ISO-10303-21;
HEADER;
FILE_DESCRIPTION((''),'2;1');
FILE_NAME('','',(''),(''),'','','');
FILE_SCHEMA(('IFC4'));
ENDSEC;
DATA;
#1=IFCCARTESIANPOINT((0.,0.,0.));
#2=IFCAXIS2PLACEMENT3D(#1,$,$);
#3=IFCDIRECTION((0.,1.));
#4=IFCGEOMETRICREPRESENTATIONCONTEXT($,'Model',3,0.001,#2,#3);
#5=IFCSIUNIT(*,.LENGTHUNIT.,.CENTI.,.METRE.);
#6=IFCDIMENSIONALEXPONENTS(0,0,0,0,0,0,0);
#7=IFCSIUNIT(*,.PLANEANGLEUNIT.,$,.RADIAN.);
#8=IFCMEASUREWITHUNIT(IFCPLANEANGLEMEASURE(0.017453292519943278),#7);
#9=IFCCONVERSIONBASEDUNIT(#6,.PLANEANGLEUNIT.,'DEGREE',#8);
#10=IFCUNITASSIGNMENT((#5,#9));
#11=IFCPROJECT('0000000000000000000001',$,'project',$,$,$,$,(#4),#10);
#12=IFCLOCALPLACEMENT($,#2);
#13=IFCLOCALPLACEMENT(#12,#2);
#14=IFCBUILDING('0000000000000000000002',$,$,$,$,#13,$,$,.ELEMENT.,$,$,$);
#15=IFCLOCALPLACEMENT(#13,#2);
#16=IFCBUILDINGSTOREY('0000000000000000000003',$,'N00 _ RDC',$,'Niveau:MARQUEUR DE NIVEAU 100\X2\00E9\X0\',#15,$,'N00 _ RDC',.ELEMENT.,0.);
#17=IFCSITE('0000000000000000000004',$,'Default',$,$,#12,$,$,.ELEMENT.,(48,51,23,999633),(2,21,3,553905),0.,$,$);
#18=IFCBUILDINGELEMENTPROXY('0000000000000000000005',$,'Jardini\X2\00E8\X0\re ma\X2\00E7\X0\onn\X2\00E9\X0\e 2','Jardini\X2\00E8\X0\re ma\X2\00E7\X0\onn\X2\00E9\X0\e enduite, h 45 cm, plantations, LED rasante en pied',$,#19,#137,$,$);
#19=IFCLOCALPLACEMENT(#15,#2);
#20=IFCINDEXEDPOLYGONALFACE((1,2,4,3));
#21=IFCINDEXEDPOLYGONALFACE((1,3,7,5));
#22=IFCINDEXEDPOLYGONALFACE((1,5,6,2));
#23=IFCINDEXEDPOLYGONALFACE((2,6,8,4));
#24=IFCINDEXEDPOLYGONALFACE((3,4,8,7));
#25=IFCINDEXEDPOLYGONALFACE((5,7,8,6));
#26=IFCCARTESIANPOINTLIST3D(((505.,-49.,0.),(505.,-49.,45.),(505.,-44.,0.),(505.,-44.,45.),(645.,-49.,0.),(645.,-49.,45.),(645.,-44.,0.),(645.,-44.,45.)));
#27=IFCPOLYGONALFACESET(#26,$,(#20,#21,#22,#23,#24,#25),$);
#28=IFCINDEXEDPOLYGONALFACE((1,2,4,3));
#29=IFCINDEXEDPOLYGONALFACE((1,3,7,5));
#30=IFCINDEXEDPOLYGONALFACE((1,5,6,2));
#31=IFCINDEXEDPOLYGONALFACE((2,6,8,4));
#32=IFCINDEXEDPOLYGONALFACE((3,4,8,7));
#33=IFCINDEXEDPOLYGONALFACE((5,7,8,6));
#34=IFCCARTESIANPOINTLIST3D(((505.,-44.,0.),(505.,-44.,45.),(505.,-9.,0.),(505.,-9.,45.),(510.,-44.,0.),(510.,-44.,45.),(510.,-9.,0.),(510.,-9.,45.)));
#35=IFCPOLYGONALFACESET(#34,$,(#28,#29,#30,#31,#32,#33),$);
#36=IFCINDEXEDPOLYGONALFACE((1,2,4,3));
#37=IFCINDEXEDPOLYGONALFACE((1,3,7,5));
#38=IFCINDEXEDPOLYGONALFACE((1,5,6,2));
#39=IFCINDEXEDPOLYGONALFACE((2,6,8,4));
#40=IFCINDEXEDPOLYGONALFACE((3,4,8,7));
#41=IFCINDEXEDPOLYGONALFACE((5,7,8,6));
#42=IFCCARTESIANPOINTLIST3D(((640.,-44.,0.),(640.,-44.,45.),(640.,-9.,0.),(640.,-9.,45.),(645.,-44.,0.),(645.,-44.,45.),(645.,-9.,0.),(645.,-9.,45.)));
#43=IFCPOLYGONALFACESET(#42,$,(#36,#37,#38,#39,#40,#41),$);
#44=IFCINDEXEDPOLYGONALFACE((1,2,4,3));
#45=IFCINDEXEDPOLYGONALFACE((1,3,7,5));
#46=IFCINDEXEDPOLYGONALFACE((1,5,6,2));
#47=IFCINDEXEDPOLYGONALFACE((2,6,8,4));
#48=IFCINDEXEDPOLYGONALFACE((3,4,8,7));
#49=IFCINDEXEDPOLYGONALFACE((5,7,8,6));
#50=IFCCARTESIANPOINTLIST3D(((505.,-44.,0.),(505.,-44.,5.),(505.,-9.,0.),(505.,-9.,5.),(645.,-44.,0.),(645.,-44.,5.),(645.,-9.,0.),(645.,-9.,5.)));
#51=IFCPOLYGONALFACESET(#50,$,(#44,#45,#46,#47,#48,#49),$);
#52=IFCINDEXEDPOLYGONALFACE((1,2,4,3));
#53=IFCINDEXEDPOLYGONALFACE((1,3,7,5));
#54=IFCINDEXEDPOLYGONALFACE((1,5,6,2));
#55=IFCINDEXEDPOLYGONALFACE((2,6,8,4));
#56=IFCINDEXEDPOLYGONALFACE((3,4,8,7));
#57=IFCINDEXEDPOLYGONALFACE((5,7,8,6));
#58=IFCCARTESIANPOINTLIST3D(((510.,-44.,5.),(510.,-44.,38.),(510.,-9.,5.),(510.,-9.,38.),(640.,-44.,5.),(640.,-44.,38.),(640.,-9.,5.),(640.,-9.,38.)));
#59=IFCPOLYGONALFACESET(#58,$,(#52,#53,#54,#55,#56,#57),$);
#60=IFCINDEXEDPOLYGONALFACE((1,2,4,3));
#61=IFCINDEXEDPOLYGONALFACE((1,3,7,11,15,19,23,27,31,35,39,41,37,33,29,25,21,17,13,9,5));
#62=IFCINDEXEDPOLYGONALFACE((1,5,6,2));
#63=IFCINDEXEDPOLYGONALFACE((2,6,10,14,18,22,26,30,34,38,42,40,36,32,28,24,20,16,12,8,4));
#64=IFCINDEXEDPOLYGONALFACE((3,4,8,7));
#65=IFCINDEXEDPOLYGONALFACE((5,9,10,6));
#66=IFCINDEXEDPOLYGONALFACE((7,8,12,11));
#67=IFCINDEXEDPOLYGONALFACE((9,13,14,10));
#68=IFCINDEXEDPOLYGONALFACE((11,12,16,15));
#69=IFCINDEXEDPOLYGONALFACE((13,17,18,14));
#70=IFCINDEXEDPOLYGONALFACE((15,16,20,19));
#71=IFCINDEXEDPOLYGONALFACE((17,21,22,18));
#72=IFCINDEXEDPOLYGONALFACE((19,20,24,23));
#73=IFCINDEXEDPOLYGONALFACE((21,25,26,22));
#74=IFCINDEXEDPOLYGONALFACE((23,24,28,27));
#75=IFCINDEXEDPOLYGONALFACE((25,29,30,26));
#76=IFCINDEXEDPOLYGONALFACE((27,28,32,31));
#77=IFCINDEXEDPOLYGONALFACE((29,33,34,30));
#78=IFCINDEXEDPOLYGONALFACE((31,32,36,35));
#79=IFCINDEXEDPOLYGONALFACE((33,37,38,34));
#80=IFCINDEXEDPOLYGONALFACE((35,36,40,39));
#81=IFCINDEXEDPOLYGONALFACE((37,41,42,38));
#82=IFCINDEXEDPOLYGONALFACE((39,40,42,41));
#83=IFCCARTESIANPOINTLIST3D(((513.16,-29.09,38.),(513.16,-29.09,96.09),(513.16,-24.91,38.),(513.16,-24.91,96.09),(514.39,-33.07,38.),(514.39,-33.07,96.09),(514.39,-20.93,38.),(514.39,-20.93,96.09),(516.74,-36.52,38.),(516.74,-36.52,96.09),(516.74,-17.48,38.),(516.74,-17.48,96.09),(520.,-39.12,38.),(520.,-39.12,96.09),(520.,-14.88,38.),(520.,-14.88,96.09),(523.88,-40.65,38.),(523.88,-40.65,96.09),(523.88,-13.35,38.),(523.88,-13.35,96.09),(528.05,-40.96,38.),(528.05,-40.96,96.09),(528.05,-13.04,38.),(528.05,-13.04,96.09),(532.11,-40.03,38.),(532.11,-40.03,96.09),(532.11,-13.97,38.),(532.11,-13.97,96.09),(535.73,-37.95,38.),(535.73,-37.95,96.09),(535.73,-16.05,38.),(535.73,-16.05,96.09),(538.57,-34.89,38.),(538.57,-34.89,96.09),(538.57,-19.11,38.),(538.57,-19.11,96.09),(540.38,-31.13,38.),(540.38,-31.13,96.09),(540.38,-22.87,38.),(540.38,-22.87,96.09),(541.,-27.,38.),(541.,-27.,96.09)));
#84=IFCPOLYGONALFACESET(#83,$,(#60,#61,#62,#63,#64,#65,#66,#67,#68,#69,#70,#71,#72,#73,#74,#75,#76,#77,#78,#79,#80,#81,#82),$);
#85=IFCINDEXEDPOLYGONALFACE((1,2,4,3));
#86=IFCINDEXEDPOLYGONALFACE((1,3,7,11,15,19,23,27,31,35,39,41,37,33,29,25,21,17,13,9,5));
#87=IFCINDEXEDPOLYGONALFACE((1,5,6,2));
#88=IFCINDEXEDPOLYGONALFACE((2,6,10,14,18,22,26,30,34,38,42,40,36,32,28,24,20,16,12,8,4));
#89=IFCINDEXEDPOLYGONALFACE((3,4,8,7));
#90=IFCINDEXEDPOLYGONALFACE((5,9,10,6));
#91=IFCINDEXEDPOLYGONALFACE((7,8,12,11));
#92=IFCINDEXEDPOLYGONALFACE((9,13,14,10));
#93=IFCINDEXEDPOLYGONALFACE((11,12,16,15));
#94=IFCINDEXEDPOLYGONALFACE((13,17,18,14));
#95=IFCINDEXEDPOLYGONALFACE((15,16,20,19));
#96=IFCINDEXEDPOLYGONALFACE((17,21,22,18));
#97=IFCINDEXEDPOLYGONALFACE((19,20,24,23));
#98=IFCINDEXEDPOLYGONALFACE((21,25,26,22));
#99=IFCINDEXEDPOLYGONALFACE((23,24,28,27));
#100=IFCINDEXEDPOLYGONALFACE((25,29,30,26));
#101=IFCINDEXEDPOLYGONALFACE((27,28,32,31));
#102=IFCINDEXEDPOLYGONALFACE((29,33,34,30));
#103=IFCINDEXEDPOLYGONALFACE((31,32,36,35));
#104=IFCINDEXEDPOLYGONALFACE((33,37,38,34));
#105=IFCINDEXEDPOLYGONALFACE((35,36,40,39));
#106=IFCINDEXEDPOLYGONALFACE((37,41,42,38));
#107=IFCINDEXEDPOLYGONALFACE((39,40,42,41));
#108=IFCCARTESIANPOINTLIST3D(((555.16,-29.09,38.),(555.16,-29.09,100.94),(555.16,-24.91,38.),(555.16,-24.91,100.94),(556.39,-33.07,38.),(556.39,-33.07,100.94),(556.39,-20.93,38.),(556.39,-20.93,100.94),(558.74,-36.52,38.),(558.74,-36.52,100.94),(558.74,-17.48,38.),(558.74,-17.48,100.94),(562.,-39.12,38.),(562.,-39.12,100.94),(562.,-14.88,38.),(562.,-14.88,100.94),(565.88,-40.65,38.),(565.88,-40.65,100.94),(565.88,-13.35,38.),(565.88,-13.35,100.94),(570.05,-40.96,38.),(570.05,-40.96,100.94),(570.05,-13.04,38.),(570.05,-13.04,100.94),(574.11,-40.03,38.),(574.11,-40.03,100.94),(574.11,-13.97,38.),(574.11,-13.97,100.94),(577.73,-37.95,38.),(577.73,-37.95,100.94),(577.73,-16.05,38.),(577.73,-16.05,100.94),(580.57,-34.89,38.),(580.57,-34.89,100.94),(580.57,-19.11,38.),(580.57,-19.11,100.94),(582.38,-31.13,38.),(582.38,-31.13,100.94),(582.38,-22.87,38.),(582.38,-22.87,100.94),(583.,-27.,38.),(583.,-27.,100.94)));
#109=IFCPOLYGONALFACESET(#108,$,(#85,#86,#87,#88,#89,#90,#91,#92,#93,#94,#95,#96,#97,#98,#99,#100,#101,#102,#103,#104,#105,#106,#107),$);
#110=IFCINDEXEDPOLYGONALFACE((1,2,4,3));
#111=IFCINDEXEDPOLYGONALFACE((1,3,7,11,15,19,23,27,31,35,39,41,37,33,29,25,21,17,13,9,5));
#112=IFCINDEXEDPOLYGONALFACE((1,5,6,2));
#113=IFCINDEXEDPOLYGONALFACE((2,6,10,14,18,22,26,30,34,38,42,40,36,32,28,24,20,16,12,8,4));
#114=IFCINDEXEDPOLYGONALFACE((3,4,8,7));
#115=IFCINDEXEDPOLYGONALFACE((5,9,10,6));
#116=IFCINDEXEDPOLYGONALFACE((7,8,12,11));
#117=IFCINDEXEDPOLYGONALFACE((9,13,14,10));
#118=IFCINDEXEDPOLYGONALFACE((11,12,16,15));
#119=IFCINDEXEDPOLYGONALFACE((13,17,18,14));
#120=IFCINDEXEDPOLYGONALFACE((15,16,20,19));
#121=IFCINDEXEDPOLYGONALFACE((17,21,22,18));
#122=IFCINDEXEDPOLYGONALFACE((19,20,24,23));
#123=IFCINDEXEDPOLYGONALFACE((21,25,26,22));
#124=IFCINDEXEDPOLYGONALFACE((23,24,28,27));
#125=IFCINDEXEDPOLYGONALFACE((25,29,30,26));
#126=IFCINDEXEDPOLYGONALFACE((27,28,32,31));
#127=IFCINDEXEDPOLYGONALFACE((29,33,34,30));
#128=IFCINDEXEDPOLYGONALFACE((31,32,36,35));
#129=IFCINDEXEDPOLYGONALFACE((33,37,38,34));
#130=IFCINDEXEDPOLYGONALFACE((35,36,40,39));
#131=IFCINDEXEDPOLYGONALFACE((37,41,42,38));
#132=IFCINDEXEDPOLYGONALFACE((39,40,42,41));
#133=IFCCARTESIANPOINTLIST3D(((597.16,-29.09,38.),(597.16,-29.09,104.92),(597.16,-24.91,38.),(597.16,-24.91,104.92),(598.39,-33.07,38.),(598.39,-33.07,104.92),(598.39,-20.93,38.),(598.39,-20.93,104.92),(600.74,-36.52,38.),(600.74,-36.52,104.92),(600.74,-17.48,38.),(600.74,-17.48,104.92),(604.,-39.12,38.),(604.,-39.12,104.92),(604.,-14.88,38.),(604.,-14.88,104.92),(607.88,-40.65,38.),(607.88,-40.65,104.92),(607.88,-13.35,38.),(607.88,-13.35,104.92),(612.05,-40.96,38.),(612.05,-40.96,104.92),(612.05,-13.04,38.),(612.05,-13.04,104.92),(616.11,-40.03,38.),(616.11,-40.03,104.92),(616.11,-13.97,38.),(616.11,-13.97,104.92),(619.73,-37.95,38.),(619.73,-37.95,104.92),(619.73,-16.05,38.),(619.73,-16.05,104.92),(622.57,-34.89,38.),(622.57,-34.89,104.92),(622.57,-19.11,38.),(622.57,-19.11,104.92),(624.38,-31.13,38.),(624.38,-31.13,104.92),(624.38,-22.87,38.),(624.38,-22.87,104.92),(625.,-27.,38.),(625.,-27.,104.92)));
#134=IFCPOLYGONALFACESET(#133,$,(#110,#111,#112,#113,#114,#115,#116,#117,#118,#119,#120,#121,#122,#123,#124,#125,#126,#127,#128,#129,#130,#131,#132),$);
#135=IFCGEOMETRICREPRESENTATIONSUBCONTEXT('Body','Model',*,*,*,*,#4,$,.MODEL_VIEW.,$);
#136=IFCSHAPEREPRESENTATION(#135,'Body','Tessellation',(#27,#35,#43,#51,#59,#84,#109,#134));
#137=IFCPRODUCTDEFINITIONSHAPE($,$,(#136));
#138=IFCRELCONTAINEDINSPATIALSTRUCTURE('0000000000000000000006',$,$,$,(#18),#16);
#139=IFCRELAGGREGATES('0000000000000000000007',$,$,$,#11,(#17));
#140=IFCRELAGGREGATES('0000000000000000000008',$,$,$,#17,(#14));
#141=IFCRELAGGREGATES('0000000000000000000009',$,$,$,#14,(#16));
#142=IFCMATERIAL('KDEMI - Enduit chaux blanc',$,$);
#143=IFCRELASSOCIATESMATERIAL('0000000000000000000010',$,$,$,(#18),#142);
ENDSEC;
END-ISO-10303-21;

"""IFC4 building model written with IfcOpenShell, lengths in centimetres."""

from ifc_helpers import new_model, entity, si_unit, converted_unit, direction, frame, frame_2d, origin, origin_with_axes, place, context, subcontext, project, spatial, rectangle, circle, extrude, material, element, save


model = new_model("IFC4")

# Units and contexts
model_context = context("Model", 3, precision=0.001, world=origin(), true_north=direction((0.0, 1.0)))
body_context = subcontext(model_context, "Body", "Model", "MODEL_VIEW")
ifc_project = project(units=[si_unit("LENGTHUNIT", "METRE", prefix="CENTI"), converted_unit("PLANEANGLEUNIT", "DEGREE", entity("IfcPlaneAngleMeasure", 0.017453292519943278), si_unit("PLANEANGLEUNIT", "RADIAN"), dimensions=[0, 0, 0, 0, 0, 0, 0])], contexts=[model_context])

# Site, building, storey
site_placement = place(None, origin())
site = spatial("IfcSite", under=ifc_project, at=site_placement, Name="Default", CompositionType="ELEMENT", RefLatitude=(48, 51, 23, 999633), RefLongitude=(2, 21, 3, 553905), RefElevation=0.0)
building_placement = place(site_placement, origin())
building = spatial("IfcBuilding", under=site, at=building_placement, CompositionType="ELEMENT")
storey_placement = place(building_placement, origin())
storey = spatial("IfcBuildingStorey", under=building, at=storey_placement, Name="N00 _ RDC", ObjectType="Niveau:MARQUEUR DE NIVEAU 100é", LongName="N00 _ RDC", CompositionType="ELEMENT", Elevation=0.0)

# Building element proxy
ifc_material_1 = material(Name="KDEMI - Enduit chaux blanc")
proxy_1_placement = place(storey_placement, origin_with_axes())
element("IfcBuildingElementProxy", 1, at=proxy_1_placement, inside=storey, material=ifc_material_1, Name="Jardinière maçonnée 2", Description="Jardinière maçonnée enduite, h 45 cm, plantations, LED rasante en pied", context=body_context, shape_type="SweptSolid", body=[
    extrude(rectangle(XDim=140.0, YDim=5.0, at=frame_2d((575.0, -46.5))), origin(), (0.0, 0.0, 1.0), 45.0),
    extrude(rectangle(XDim=5.0, YDim=35.0, at=frame_2d((507.5, -26.5))), origin(), (0.0, 0.0, 1.0), 45.0),
    extrude(rectangle(XDim=5.0, YDim=35.0, at=frame_2d((642.5, -26.5))), origin(), (0.0, 0.0, 1.0), 45.0),
    extrude(rectangle(XDim=140.0, YDim=35.0, at=frame_2d((575.0, -26.5))), origin(), (0.0, 0.0, 1.0), 5.0),
    extrude(rectangle(XDim=130.0, YDim=35.0, at=frame_2d((575.0, -26.5))), frame((0.0, 0.0, 5.0)), (0.0, 0.0, 1.0), 33.0),
    extrude(circle(Radius=14.0, at=frame_2d((527.0, -27.0))), frame((0.0, 0.0, 38.0)), (0.0, 0.0, 1.0), 58.09),
    extrude(circle(Radius=14.0, at=frame_2d((569.0, -27.0))), frame((0.0, 0.0, 38.0)), (0.0, 0.0, 1.0), 62.94),
    extrude(circle(Radius=14.0, at=frame_2d((611.0, -27.0))), frame((0.0, 0.0, 38.0)), (0.0, 0.0, 1.0), 66.92),
])

save(model, "model.ifc")
